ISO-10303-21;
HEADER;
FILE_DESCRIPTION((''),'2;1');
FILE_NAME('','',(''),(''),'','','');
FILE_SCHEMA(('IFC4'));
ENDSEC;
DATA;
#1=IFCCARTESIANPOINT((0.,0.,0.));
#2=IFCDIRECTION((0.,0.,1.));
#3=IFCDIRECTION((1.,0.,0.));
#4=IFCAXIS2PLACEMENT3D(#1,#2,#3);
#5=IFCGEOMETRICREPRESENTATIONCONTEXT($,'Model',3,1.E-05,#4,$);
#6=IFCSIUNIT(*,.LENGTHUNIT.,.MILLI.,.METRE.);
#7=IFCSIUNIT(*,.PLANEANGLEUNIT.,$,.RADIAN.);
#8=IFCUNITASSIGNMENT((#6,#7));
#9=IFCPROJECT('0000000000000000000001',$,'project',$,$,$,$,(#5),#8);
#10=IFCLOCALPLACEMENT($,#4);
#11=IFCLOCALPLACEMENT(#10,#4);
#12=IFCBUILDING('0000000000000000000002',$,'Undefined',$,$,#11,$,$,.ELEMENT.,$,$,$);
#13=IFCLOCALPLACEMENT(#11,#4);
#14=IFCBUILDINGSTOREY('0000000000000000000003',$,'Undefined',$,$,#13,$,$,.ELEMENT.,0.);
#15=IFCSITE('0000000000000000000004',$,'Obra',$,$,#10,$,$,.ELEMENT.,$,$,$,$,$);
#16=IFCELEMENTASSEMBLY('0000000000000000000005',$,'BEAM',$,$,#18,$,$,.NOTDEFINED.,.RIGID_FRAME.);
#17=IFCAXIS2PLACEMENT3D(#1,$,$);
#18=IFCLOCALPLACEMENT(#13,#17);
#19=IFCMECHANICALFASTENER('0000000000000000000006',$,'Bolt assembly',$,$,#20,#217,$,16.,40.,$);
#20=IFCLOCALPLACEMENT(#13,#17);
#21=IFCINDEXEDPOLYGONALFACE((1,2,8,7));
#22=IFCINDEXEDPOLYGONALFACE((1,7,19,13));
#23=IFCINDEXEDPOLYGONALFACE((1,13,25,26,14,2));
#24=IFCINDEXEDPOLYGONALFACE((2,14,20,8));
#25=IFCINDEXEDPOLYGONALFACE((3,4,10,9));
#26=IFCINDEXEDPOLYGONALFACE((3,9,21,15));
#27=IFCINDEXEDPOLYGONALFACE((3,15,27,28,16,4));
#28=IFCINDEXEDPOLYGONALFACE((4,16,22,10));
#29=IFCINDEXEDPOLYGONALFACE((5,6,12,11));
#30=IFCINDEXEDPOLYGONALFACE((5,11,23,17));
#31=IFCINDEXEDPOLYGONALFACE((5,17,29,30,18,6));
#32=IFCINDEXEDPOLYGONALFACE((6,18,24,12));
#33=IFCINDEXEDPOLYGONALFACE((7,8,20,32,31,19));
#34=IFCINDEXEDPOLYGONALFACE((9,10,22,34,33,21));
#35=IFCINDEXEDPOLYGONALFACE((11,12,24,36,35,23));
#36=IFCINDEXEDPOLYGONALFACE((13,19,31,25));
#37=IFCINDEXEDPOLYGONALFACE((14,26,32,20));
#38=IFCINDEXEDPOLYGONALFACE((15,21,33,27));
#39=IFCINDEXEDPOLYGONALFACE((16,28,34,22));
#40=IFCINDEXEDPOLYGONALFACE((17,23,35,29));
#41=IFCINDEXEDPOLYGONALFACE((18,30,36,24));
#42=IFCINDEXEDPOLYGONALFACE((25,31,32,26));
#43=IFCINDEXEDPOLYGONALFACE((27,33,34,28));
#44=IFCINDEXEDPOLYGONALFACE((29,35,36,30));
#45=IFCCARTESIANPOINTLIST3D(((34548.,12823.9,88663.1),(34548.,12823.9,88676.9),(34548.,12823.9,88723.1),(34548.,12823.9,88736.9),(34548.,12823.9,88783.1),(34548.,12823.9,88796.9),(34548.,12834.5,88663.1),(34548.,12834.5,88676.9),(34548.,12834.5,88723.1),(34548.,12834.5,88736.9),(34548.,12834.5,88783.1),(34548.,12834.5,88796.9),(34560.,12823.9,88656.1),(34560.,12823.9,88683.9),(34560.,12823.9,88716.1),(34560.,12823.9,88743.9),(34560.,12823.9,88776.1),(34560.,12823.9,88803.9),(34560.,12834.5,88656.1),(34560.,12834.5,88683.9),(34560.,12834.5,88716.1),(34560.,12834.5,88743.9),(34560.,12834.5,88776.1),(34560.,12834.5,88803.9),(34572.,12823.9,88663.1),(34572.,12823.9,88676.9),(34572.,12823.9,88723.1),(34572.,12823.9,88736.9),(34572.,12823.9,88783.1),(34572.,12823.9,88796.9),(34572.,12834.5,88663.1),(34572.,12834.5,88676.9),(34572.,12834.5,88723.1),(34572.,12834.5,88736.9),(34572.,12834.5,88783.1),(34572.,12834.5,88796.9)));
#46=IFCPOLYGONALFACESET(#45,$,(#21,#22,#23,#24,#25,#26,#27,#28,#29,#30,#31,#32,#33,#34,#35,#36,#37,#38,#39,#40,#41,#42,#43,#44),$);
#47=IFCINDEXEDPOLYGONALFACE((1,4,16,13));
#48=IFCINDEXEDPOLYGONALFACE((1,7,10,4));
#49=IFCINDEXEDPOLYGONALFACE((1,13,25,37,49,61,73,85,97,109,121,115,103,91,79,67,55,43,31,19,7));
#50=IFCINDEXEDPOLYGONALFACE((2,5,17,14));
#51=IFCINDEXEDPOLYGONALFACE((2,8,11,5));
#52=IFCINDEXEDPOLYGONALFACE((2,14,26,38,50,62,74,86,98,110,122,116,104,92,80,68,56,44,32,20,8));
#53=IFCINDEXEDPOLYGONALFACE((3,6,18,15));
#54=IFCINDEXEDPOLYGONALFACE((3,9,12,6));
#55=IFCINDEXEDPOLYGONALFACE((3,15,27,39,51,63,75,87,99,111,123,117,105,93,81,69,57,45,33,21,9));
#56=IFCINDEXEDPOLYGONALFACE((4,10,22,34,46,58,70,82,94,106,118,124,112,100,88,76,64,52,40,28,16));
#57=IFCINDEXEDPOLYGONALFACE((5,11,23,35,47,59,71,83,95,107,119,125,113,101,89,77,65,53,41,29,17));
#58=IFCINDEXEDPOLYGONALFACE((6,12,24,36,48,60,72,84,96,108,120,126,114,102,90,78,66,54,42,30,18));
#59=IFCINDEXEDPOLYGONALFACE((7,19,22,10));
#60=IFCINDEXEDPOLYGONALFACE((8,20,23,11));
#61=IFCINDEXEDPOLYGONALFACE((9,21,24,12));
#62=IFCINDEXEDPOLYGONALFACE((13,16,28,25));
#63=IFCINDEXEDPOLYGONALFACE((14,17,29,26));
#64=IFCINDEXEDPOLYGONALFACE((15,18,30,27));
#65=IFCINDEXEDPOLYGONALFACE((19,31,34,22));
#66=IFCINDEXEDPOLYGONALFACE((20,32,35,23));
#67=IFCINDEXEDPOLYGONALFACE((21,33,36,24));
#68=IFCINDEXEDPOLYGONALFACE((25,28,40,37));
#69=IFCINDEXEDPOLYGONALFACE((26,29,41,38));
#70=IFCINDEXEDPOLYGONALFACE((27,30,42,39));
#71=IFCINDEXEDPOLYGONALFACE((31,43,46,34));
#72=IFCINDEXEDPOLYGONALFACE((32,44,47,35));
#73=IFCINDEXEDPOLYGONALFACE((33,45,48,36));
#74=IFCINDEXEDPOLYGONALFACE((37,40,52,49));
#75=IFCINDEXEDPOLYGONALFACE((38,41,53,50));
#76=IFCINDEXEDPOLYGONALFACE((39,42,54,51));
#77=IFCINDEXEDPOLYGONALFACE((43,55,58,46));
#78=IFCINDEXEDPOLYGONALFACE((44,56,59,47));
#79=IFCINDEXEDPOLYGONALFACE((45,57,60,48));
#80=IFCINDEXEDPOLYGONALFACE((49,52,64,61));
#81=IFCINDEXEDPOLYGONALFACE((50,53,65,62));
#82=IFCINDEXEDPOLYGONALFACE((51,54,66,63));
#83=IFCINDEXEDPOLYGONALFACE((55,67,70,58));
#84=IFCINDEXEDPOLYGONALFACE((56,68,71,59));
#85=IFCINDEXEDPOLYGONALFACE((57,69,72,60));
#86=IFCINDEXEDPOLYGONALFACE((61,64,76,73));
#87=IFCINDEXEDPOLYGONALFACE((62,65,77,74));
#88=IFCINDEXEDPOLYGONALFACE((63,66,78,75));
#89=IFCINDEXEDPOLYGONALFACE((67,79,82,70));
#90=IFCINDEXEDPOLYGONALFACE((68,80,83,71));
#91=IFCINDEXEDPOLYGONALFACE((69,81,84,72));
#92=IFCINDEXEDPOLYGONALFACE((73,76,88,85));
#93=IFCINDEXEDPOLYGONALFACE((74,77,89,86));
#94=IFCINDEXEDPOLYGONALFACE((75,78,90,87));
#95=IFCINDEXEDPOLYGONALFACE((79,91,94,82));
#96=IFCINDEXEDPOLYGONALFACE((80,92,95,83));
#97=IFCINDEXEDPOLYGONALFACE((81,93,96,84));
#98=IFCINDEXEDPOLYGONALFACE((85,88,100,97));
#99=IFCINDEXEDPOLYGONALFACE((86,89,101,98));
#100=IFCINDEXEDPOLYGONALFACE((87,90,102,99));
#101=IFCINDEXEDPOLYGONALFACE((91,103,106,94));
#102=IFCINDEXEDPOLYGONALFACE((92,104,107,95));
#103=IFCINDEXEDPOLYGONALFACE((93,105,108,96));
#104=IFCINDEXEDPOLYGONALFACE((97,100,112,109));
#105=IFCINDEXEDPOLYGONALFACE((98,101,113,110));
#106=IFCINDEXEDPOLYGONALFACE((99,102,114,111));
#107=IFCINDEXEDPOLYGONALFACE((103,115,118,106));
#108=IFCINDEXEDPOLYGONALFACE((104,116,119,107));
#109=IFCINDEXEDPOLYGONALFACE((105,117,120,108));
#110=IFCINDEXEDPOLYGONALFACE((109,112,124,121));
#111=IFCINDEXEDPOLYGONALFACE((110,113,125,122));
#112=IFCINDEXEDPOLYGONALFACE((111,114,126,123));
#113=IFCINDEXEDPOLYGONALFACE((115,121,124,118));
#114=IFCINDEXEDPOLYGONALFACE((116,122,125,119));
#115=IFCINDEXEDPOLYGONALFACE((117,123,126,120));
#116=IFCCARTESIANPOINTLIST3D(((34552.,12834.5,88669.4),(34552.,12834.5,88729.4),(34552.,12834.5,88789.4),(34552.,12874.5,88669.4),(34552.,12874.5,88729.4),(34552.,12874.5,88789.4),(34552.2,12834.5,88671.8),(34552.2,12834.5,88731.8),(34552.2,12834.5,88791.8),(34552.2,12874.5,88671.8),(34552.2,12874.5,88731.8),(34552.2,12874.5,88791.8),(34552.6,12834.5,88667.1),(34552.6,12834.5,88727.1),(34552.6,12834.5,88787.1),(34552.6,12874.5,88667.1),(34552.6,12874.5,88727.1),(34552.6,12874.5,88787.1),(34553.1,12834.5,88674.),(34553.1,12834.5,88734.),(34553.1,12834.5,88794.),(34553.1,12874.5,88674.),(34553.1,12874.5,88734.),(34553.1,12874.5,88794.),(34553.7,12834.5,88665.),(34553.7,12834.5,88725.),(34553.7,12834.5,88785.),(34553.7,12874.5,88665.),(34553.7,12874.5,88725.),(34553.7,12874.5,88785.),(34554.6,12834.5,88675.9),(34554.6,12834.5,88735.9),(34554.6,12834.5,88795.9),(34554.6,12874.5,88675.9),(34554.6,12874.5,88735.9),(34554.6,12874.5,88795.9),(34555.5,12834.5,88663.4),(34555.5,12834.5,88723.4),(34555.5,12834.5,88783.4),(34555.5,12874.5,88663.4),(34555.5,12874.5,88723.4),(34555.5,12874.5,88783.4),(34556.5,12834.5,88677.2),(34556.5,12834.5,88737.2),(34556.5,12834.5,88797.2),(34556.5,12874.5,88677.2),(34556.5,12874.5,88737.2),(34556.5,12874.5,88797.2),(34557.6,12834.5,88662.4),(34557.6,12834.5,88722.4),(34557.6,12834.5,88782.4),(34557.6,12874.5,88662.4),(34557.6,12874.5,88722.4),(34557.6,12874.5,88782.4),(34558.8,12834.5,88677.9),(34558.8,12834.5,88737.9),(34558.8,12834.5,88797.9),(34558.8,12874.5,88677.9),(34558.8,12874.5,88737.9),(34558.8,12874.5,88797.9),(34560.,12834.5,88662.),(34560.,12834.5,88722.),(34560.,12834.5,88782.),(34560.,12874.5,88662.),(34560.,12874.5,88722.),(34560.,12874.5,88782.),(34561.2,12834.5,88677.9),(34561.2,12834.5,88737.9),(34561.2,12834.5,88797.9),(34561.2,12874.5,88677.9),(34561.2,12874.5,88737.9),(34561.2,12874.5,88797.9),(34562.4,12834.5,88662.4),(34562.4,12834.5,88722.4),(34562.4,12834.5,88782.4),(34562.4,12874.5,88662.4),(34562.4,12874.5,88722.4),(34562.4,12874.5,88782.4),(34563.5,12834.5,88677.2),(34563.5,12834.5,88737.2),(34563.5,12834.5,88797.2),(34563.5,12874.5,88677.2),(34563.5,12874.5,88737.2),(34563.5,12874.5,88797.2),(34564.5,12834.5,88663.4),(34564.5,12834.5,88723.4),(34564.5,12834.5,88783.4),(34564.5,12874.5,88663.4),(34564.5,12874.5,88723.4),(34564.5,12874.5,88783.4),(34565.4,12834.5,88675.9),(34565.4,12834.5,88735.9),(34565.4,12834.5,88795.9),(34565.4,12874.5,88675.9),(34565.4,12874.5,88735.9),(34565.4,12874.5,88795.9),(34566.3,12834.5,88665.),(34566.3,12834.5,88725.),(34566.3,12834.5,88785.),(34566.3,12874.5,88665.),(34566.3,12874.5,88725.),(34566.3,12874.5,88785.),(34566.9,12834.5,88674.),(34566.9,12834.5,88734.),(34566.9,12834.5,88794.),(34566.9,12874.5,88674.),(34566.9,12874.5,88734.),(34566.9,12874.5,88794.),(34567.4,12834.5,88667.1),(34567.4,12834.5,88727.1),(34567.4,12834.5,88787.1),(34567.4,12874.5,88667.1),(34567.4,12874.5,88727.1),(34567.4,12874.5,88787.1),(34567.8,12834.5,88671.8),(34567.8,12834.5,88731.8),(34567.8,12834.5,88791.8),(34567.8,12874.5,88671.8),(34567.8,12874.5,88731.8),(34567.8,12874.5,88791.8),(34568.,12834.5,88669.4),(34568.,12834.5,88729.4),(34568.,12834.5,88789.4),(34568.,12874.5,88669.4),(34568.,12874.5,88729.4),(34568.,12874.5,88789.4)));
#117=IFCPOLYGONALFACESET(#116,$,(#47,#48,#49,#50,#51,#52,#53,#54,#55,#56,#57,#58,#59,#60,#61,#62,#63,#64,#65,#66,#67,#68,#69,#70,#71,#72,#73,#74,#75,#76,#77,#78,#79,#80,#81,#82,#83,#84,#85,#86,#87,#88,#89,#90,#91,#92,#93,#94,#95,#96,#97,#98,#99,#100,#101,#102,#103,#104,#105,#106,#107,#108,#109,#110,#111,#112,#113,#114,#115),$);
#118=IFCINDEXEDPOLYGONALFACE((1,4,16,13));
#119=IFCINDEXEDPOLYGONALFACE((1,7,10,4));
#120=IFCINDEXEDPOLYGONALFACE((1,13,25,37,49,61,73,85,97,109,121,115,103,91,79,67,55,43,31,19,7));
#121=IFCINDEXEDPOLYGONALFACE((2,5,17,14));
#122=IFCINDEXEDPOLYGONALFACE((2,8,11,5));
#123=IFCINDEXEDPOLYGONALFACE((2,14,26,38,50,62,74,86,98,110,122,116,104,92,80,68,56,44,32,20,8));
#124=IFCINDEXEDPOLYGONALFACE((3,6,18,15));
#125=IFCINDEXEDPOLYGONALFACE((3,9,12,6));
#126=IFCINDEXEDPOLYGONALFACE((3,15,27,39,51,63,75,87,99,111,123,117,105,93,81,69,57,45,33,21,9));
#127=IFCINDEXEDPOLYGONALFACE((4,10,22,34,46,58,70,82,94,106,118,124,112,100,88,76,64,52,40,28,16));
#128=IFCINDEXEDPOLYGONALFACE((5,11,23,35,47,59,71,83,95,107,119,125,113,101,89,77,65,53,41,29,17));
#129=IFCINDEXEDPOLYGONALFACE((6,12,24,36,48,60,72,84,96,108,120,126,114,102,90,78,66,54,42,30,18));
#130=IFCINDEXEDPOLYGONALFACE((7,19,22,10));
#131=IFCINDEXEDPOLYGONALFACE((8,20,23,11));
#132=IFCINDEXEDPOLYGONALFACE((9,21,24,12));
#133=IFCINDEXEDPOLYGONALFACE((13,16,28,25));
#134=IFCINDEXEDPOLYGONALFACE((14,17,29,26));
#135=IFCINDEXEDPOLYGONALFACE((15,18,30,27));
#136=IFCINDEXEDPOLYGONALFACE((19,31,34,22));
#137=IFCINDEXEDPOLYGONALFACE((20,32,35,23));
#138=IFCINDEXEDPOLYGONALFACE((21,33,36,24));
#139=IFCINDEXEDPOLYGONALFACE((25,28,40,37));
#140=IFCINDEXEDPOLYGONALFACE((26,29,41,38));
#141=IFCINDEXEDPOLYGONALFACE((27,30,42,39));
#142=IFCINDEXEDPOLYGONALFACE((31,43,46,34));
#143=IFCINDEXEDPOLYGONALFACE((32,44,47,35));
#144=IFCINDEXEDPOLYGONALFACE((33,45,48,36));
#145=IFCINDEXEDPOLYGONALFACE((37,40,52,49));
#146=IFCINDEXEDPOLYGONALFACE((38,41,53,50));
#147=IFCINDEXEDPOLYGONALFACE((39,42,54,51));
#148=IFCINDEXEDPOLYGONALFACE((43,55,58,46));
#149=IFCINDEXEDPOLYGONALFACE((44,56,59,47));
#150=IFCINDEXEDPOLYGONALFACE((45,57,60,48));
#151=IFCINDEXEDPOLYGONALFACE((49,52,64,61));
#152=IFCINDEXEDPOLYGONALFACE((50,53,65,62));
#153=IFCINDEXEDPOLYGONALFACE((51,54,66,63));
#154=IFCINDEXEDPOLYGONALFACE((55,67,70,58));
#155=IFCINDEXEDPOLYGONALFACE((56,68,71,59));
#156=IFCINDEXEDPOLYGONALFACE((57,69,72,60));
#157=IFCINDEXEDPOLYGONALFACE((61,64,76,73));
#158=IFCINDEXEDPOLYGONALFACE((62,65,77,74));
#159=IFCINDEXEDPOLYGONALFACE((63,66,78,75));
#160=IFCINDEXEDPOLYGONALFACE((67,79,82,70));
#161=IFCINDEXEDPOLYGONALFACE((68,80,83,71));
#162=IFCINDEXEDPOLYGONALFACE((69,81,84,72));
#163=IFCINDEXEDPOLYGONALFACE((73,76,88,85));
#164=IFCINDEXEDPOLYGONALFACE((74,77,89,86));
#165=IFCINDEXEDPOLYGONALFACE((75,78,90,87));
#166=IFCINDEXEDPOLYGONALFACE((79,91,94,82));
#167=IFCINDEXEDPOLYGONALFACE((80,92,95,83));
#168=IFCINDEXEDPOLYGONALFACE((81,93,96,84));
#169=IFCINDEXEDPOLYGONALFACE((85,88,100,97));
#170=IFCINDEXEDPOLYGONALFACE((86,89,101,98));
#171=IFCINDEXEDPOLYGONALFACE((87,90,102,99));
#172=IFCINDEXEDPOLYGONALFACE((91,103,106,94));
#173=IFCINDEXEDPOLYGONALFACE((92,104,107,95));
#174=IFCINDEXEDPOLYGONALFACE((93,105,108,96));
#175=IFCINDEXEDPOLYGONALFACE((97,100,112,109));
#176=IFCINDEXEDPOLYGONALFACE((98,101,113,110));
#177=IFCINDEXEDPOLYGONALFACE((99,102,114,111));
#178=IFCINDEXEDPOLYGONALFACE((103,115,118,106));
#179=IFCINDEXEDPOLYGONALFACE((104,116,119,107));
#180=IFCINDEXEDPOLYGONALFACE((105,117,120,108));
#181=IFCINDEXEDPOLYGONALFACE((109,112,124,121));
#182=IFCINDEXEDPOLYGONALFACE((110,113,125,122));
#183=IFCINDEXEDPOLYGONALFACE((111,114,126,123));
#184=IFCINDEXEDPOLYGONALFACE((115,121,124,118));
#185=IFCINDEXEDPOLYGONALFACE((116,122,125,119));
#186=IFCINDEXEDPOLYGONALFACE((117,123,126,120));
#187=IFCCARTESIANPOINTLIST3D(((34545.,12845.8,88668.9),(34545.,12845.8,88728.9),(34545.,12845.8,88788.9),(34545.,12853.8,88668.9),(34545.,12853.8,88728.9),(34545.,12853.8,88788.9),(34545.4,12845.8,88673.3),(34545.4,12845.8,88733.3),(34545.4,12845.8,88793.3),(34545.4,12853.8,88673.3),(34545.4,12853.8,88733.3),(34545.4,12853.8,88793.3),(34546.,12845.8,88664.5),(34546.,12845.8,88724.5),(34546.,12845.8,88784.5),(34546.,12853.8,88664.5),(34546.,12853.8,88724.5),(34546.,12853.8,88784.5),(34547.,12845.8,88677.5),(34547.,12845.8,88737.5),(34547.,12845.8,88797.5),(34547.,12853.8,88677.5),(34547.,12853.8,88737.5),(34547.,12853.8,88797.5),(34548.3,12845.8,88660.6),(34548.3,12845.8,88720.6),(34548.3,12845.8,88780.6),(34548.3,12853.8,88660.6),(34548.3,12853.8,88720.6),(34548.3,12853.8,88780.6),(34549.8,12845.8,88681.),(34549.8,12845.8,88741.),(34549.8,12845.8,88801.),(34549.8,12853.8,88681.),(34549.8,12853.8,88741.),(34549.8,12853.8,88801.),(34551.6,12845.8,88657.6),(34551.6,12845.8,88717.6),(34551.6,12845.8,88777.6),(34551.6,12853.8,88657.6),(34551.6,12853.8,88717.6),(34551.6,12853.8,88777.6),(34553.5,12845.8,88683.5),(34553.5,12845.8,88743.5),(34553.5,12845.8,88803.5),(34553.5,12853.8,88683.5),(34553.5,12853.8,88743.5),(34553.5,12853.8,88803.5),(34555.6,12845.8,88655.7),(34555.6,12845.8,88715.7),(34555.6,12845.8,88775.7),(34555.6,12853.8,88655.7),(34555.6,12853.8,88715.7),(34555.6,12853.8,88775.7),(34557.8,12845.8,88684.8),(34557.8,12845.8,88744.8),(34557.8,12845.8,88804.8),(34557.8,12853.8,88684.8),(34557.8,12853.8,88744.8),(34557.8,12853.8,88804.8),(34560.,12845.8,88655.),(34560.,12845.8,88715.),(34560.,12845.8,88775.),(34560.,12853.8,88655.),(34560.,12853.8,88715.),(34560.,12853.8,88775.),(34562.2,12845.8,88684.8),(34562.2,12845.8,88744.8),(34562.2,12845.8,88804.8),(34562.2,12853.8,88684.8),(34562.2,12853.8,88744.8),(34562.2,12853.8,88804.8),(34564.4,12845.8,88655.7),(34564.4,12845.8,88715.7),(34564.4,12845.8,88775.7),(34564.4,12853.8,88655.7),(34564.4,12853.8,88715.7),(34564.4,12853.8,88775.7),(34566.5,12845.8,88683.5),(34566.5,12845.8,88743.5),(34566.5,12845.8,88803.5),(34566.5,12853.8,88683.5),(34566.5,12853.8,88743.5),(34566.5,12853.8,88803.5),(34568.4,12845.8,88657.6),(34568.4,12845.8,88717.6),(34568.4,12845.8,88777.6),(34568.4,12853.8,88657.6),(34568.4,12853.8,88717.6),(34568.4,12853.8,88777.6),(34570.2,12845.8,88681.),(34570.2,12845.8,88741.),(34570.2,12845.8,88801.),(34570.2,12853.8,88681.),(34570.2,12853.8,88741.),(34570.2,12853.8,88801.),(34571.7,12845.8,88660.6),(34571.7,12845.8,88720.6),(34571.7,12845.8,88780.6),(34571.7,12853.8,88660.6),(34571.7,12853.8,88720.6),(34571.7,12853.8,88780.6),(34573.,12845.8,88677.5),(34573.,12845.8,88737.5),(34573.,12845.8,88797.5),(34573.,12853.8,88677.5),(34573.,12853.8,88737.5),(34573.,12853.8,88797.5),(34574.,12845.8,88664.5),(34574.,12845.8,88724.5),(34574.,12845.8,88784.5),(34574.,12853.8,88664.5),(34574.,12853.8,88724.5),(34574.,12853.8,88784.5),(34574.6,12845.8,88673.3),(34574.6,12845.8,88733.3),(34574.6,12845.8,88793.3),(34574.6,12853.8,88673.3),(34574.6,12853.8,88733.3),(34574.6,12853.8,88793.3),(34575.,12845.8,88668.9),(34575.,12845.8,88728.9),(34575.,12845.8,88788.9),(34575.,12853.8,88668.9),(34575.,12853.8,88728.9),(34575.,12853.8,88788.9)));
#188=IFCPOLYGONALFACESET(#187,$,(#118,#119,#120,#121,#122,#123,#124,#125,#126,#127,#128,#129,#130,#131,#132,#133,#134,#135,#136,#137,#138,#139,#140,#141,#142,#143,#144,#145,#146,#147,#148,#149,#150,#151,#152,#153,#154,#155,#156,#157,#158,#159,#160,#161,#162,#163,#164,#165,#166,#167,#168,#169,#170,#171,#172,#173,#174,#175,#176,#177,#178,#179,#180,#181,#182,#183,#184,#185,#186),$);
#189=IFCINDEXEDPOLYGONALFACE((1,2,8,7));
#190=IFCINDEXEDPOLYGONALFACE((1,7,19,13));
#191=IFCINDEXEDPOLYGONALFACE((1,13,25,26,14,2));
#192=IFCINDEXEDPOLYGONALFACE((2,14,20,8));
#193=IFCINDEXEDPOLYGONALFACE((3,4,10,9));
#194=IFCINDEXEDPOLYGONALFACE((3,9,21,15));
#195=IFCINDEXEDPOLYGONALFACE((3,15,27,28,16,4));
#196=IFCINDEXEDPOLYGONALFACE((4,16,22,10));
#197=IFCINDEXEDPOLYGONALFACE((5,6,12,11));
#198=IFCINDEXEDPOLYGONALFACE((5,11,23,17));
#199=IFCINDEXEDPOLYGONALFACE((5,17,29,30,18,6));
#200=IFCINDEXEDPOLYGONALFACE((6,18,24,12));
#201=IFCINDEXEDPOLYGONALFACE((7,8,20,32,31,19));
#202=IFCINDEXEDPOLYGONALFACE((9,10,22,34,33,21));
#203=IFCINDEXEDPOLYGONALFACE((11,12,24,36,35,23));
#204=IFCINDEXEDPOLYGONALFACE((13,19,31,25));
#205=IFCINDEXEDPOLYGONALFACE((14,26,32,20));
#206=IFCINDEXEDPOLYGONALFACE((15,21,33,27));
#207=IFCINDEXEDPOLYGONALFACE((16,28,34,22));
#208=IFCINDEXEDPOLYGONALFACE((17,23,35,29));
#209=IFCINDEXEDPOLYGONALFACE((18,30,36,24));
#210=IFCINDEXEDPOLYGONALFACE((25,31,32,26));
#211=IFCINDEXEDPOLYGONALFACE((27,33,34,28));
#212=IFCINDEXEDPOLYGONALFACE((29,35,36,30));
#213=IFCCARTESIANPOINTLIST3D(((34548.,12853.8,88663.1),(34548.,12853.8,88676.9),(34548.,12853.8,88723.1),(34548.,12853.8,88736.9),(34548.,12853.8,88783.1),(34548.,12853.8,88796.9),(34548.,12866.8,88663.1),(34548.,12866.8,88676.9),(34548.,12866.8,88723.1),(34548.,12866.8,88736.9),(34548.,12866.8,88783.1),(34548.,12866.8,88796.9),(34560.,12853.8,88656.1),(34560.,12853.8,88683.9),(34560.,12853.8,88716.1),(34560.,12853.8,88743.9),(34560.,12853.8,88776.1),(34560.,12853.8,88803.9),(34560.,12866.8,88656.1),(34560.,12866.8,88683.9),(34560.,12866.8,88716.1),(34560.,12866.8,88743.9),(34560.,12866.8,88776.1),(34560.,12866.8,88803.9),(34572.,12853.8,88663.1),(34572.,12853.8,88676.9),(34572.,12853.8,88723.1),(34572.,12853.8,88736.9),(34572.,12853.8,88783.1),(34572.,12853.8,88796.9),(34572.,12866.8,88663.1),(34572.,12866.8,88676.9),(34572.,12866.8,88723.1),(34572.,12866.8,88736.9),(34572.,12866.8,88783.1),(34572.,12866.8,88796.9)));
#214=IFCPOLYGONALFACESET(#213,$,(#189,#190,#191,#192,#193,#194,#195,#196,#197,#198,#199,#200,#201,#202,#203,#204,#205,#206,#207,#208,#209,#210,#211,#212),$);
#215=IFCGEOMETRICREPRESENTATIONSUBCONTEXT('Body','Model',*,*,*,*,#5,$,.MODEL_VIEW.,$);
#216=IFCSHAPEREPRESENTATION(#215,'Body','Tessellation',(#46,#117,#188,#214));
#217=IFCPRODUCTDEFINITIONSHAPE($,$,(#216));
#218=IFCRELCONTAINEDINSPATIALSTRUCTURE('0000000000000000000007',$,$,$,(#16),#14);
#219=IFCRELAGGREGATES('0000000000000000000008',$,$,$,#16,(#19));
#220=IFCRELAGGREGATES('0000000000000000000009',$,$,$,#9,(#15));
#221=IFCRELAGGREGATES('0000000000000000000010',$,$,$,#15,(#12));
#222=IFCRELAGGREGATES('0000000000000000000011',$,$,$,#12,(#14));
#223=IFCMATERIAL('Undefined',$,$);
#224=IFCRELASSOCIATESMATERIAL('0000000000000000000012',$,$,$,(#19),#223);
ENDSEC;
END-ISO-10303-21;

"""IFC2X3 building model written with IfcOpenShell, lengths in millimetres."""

from ifc_helpers import new_model, si_unit, frame, origin_with_axes, origin_2d_with_axis, place, context, subcontext, project, spatial, polyline, circle, outline, extrude, source, transform, mapped, material, element, aggregate, save


model = new_model("IFC2X3")

# Units and contexts
model_context = context("Model", 3, precision=1e-05, world=origin_with_axes())
body_context = subcontext(model_context, "Body", "Model", "MODEL_VIEW")
ifc_project = project(units=[si_unit("LENGTHUNIT", "METRE", prefix="MILLI"), si_unit("PLANEANGLEUNIT", "RADIAN")], contexts=[model_context])

# Site, building, storey
site_placement = place(None, origin_with_axes())
site = spatial("IfcSite", under=ifc_project, at=site_placement, Name="Obra", CompositionType="ELEMENT")
building_placement = place(site_placement, origin_with_axes())
building = spatial("IfcBuilding", under=site, at=building_placement, Name="Undefined", CompositionType="ELEMENT")
storey_placement = place(building_placement, origin_with_axes())
storey = spatial("IfcBuildingStorey", under=building, at=storey_placement, Name="Undefined", CompositionType="ELEMENT", Elevation=0.0)

# Shared definitions
ifc_material_1 = material(Name="Undefined")

# Element assembly, mechanical fastener
assembly_1_placement = place(storey_placement, origin_with_axes())
assembly_1 = element("IfcElementAssembly", 1, at=assembly_1_placement, inside=storey, Name="BEAM", AssemblyPlace="NOTDEFINED", PredefinedType="RIGID_FRAME")
shared_shape_1 = source(origin_with_axes(), body_context, "Body", "SweptSolid", [
    extrude(outline(polyline([(13.9, 0.0), (6.9, 12.0), (-6.9, 12.0), (-13.9, 0.0), (-6.9, -12.0), (6.9, -12.0), (13.9, 0.0)])), frame((0.0, -19.7, 0.0), z_axis=(0.0, 1.0, 0.0), x_axis=(1.0, 0.0, 0.0)), (0.0, 0.0, 1.0), 10.6),
    extrude(circle(Radius=8.0, at=origin_2d_with_axis()), frame((0.0, -9.1, 0.0), z_axis=(0.0, 1.0, 0.0), x_axis=(1.0, 0.0, 0.0)), (0.0, 0.0, 1.0), 40.0),
    extrude(circle(Radius=15.0, at=origin_2d_with_axis()), frame((0.0, 2.2, 0.0), z_axis=(0.0, 1.0, 0.0), x_axis=(1.0, 0.0, 0.0)), (0.0, 0.0, 1.0), 8.0),
    extrude(outline(polyline([(13.9, 0.0), (6.9, 12.0), (-6.9, 12.0), (-13.9, 0.0), (-6.9, -12.0), (6.9, -12.0), (13.9, 0.0)])), frame((0.0, 10.2, 0.0), z_axis=(0.0, 1.0, 0.0), x_axis=(1.0, 0.0, 0.0)), (0.0, 0.0, 1.0), 13.0),
])
mechanical_fastener_1_placement = place(assembly_1_placement, frame((34510.0, 12843.6, 88850.0), z_axis=(1.0, 0.0, 0.0), x_axis=(0.0, 0.0, -1.0)))
mechanical_fastener_1 = element("IfcMechanicalFastener", 2, at=mechanical_fastener_1_placement, material=ifc_material_1, Name="Bolt assembly", NominalDiameter=16.0, NominalLength=40.0, context=body_context, shape_type="MappedRepresentation", body=[
    mapped(shared_shape_1, transform((60.0, 0.0, 50.0))),
    mapped(shared_shape_1, transform((120.0, 0.0, 50.0))),
    mapped(shared_shape_1, transform((180.0, 0.0, 50.0))),
])
aggregate(assembly_1, [mechanical_fastener_1])

save(model, "model.ifc")
